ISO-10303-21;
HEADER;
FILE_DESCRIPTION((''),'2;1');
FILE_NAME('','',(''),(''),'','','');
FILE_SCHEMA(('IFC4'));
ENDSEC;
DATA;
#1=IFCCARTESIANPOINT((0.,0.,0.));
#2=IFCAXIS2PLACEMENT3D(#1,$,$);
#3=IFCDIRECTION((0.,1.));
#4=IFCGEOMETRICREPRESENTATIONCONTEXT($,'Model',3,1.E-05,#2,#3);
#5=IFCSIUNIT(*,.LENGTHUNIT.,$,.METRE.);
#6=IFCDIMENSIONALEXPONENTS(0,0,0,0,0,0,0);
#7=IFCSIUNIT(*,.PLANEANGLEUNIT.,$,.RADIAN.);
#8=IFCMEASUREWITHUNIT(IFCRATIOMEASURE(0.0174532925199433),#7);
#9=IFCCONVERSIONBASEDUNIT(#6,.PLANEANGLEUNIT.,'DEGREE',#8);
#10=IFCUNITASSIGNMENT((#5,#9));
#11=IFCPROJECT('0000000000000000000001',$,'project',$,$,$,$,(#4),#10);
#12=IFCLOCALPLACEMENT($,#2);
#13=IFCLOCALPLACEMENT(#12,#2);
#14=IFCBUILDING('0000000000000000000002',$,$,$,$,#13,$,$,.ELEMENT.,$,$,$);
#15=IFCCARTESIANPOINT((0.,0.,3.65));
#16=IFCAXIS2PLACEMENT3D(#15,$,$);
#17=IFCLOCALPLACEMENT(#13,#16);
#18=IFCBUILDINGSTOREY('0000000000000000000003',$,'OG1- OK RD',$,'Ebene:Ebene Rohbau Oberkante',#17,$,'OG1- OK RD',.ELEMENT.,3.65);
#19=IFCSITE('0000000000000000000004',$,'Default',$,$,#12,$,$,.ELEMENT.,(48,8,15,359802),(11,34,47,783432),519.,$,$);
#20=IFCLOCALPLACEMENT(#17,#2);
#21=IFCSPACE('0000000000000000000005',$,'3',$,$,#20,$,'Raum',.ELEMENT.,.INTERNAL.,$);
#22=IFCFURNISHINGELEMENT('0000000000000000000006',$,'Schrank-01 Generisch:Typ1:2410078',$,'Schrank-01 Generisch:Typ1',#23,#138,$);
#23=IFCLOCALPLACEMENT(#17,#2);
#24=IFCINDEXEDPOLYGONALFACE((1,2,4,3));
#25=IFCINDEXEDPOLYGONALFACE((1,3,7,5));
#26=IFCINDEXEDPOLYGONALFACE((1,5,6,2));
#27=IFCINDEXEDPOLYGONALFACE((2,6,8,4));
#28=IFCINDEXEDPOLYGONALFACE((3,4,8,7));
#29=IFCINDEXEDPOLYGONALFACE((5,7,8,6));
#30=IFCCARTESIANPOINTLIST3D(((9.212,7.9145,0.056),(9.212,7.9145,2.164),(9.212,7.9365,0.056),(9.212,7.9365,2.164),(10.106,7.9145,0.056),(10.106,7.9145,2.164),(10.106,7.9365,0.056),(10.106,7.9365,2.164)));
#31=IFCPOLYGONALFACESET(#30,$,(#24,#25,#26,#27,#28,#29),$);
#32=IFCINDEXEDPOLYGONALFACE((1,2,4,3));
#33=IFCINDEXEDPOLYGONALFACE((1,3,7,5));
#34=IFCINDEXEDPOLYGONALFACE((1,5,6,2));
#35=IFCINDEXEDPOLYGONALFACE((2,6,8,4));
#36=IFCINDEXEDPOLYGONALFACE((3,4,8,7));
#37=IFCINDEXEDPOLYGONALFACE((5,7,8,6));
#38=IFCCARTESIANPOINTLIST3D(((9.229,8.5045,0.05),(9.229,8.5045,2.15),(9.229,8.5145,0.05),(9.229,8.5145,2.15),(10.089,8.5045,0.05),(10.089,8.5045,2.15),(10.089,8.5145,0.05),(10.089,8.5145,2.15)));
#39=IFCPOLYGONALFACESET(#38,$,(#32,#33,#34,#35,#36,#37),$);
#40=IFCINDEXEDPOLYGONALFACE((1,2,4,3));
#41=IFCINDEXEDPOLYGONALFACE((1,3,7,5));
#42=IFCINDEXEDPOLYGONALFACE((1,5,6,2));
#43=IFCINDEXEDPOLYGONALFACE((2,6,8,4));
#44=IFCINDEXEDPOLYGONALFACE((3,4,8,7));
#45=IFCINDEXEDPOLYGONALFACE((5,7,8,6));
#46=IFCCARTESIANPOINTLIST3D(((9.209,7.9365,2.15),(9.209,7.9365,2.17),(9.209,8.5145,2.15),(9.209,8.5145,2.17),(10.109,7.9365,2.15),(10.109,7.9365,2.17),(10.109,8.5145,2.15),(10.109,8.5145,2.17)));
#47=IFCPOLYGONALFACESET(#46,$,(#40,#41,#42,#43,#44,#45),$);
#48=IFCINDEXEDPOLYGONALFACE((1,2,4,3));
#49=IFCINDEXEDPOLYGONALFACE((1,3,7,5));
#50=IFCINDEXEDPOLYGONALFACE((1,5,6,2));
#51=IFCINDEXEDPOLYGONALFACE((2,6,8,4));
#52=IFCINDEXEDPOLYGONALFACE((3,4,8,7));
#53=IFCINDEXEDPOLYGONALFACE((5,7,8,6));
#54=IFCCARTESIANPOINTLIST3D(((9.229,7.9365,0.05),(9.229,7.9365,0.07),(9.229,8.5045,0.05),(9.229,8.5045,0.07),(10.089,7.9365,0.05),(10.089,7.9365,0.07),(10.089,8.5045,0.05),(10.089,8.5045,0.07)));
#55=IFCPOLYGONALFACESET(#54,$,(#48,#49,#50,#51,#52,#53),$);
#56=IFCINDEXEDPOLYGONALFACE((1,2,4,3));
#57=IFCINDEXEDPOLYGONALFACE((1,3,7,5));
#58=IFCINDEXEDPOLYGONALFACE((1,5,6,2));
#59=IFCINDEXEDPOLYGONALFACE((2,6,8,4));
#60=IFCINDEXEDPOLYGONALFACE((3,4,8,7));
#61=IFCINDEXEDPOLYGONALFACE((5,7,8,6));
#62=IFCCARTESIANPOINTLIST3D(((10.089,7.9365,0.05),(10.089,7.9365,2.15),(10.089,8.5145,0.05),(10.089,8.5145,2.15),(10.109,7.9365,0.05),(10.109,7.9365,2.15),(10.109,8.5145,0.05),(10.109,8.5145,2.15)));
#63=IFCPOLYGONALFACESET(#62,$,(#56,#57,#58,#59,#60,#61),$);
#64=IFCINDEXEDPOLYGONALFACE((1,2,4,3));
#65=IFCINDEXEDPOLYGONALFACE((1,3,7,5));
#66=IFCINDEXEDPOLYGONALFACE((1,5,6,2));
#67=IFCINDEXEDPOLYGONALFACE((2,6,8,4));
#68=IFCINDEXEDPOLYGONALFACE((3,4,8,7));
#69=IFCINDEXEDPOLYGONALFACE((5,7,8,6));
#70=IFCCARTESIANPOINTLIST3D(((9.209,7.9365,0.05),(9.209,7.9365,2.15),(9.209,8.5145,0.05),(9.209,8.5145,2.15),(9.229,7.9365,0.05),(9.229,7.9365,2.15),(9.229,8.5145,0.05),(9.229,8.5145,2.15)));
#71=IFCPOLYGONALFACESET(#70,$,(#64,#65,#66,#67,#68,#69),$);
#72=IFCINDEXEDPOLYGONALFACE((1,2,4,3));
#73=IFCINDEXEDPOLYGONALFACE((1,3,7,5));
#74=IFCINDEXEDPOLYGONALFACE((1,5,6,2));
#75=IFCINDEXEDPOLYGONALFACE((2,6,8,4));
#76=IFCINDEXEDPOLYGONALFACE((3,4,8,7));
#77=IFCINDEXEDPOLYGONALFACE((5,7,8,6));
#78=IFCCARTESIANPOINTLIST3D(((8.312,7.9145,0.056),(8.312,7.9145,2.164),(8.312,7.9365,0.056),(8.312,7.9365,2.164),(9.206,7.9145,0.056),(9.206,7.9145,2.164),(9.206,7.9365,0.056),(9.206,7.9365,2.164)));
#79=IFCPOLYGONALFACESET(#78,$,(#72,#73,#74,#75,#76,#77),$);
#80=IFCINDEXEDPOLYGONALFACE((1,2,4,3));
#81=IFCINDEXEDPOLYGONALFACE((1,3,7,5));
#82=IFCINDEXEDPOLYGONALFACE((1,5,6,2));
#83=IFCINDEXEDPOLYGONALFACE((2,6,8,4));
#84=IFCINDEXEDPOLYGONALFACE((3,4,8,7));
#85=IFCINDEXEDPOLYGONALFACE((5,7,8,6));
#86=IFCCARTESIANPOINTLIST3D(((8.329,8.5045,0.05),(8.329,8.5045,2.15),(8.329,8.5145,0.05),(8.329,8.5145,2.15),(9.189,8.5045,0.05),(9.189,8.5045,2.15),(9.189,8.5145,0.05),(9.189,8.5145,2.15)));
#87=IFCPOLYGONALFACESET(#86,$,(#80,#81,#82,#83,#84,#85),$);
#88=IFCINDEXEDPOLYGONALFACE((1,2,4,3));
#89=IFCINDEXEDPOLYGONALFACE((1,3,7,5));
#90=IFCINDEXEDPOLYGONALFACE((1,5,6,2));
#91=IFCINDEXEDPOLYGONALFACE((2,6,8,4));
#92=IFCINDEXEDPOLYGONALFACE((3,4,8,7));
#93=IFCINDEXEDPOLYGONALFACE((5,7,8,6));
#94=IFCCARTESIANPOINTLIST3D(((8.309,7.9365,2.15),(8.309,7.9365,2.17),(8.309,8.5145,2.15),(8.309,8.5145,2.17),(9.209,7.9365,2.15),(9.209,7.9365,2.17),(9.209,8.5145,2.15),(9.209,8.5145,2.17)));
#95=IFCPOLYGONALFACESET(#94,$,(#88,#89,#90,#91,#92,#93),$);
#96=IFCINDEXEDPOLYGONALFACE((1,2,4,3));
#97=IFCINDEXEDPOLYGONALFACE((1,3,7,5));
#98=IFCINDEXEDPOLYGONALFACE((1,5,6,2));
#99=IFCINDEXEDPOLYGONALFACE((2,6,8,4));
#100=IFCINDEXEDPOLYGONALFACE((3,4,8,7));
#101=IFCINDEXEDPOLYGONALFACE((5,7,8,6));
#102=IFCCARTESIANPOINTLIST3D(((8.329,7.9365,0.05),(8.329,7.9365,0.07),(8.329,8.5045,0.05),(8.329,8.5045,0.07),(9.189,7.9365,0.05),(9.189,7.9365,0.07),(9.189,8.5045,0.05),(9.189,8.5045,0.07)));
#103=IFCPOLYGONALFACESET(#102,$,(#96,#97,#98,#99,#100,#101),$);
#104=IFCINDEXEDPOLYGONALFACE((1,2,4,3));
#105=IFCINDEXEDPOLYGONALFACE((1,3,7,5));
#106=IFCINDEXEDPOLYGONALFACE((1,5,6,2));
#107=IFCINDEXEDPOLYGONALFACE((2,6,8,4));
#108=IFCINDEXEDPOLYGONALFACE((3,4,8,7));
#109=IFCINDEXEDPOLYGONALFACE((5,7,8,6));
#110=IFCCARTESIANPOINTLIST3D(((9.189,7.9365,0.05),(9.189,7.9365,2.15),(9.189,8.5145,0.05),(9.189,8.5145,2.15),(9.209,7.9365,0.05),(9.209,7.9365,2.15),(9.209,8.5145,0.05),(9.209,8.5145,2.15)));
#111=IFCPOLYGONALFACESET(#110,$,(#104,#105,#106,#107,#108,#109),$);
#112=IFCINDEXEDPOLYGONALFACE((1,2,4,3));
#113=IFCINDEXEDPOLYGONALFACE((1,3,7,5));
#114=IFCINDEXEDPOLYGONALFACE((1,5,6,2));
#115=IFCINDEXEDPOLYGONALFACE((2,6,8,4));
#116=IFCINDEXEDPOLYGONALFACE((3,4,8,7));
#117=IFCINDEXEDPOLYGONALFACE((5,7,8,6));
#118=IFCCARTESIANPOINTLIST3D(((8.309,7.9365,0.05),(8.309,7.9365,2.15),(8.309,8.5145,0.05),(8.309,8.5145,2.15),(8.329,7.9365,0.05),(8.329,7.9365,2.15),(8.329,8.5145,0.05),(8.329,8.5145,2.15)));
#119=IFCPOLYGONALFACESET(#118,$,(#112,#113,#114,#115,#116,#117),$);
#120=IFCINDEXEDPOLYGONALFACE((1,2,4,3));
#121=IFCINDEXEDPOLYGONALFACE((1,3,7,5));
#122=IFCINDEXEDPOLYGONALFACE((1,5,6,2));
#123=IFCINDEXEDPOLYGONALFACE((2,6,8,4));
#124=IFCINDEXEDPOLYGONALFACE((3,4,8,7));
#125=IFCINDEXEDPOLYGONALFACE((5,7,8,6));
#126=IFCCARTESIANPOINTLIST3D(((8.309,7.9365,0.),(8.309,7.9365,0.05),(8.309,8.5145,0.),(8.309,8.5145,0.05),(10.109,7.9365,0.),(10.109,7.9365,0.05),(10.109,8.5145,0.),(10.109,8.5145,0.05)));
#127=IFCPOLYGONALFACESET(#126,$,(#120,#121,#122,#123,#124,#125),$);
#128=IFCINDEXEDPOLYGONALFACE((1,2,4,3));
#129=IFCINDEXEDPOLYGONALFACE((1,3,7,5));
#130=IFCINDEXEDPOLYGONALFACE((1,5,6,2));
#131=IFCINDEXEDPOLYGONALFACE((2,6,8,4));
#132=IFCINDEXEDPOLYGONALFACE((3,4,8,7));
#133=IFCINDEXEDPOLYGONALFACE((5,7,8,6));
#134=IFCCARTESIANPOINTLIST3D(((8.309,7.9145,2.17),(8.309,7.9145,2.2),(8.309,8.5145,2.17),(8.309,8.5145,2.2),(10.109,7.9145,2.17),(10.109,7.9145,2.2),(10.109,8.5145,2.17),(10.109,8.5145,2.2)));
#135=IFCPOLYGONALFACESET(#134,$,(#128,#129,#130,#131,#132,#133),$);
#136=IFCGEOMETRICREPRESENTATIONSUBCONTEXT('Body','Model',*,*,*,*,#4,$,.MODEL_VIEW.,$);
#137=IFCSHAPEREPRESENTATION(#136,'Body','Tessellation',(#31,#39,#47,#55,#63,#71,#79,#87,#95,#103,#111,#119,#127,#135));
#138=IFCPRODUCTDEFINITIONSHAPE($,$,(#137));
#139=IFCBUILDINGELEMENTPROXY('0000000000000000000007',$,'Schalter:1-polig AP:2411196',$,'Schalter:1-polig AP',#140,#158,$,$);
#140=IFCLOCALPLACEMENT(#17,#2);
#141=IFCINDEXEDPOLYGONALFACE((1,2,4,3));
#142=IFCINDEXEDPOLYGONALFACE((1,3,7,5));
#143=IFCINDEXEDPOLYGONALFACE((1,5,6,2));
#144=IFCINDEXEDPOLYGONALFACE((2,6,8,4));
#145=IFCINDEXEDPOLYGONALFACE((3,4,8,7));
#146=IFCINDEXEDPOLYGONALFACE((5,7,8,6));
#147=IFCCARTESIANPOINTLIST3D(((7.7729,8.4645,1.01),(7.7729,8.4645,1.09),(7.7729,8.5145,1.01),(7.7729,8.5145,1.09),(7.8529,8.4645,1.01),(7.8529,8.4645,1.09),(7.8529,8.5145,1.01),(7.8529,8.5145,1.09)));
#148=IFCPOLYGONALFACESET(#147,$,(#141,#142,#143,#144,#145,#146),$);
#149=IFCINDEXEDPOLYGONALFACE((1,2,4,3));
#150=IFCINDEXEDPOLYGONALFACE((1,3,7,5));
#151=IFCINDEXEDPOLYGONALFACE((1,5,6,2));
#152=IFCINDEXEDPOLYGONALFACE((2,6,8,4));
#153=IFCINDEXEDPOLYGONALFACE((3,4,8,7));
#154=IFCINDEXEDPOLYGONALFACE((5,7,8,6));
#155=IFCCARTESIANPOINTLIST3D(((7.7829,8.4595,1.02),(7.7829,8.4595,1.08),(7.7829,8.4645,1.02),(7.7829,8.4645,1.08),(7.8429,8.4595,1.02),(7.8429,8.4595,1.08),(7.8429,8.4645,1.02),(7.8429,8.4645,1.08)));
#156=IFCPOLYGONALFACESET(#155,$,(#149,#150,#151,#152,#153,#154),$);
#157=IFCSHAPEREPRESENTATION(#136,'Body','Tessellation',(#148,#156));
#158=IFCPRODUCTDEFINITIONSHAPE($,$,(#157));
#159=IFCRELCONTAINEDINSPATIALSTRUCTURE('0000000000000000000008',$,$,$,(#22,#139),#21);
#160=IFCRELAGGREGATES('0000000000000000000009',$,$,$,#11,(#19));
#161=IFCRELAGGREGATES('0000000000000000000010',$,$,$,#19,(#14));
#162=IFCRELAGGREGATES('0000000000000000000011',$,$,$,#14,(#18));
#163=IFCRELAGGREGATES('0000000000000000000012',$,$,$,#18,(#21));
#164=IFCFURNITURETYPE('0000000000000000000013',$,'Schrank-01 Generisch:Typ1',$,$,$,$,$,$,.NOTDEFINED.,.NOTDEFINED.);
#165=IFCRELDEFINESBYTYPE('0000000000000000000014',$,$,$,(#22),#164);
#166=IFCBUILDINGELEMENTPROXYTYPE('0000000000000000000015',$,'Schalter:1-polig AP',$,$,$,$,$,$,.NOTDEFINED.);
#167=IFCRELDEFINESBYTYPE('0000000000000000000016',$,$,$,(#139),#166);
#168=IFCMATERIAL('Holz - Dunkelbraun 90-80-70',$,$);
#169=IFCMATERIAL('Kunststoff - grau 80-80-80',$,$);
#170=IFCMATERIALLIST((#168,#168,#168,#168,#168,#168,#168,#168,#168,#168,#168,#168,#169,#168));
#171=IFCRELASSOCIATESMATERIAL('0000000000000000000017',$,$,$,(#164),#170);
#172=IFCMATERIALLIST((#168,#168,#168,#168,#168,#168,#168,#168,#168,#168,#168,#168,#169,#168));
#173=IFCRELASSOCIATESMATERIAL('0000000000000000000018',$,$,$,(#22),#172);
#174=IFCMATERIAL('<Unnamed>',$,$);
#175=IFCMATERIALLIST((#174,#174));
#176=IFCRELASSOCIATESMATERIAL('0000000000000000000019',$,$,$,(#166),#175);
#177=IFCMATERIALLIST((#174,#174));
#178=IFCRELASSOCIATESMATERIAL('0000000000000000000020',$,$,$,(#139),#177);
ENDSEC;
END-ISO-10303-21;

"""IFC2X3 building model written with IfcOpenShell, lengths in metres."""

from ifc_helpers import new_model, entity, si_unit, converted_unit, direction, frame, frame_2d, origin, origin_2d_with_axis, place, context, subcontext, project, spatial, rectangle, extrude, source, transform, mapped, material, material_list, type_object, type_shapes, element, save


model = new_model("IFC2X3")

# Units and contexts
model_context = context("Model", 3, precision=1e-05, world=origin(), true_north=direction((0.0, 1.0)))
body_context = subcontext(model_context, "Body", "Model", "MODEL_VIEW")
ifc_project = project(units=[si_unit("LENGTHUNIT", "METRE"), converted_unit("PLANEANGLEUNIT", "DEGREE", entity("IfcRatioMeasure", 0.0174532925199433), si_unit("PLANEANGLEUNIT", "RADIAN"), dimensions=[0, 0, 0, 0, 0, 0, 0])], contexts=[model_context])

# Site, building, storey
site_placement = place(None, origin())
site = spatial("IfcSite", under=ifc_project, at=site_placement, Name="Default", CompositionType="ELEMENT", RefLatitude=(48, 8, 15, 359802), RefLongitude=(11, 34, 47, 783432), RefElevation=519.0)
building_placement = place(site_placement, origin())
building = spatial("IfcBuilding", under=site, at=building_placement, CompositionType="ELEMENT")
storey_placement = place(building_placement, frame((0.0, 0.0, 3.65)))
storey = spatial("IfcBuildingStorey", under=building, at=storey_placement, Name="OG1- OK RD", ObjectType="Ebene:Ebene Rohbau Oberkante", LongName="OG1- OK RD", CompositionType="ELEMENT", Elevation=3.65)

# Shared definitions
space_placement = place(storey_placement, origin())
space = spatial("IfcSpace", under=storey, at=space_placement, Name="3", LongName="Raum", CompositionType="ELEMENT", InteriorOrExteriorSpace="INTERNAL")

# Furnishing element
ifc_material_1 = material(Name="Holz - Dunkelbraun 90-80-70")
ifc_material_2 = material(Name="Kunststoff - grau 80-80-80")
ifc_material_list_1 = material_list([ifc_material_1, ifc_material_1, ifc_material_1, ifc_material_1, ifc_material_1, ifc_material_1, ifc_material_1, ifc_material_1, ifc_material_1, ifc_material_1, ifc_material_1, ifc_material_1, ifc_material_2, ifc_material_1])
ifc_material_list_2 = material_list([ifc_material_1, ifc_material_1, ifc_material_1, ifc_material_1, ifc_material_1, ifc_material_1, ifc_material_1, ifc_material_1, ifc_material_1, ifc_material_1, ifc_material_1, ifc_material_1, ifc_material_2, ifc_material_1])
furniture_type_1 = type_object("IfcFurnitureType", Name="Schrank-01 Generisch:Typ1", material=ifc_material_list_2)
shared_shape_1 = source(origin(), body_context, "Body", "SweptSolid", [
    extrude(rectangle(XDim=0.894, YDim=0.022, at=frame_2d((0.0, 0.0), x_axis=(1.0, 0.0))), frame((0.45, -0.289, 0.056), z_axis=(0.0, 0.0, 1.0), x_axis=(-1.0, 0.0, 0.0)), (0.0, 0.0, 1.0), 2.108),
    extrude(rectangle(XDim=0.86, YDim=0.01, at=origin_2d_with_axis()), frame((0.45, 0.295, 0.05), z_axis=(0.0, 0.0, 1.0), x_axis=(-1.0, 0.0, 0.0)), (0.0, 0.0, 1.0), 2.1),
    extrude(rectangle(XDim=0.9, YDim=0.578, at=origin_2d_with_axis()), frame((0.45, 0.011, 2.15), z_axis=(0.0, 0.0, 1.0), x_axis=(-1.0, 0.0, 0.0)), (0.0, 0.0, 1.0), 0.02),
    extrude(rectangle(XDim=0.86, YDim=0.568, at=origin_2d_with_axis()), frame((0.45, 0.006, 0.05), z_axis=(0.0, 0.0, 1.0), x_axis=(-1.0, 0.0, 0.0)), (0.0, 0.0, 1.0), 0.02),
    extrude(rectangle(XDim=0.02, YDim=0.578, at=origin_2d_with_axis()), frame((0.89, 0.011, 0.05), z_axis=(0.0, 0.0, 1.0), x_axis=(-1.0, 0.0, 0.0)), (0.0, 0.0, 1.0), 2.1),
    extrude(rectangle(XDim=0.02, YDim=0.578, at=origin_2d_with_axis()), frame((0.01, 0.011, 0.05), z_axis=(0.0, 0.0, 1.0), x_axis=(-1.0, 0.0, 0.0)), (0.0, 0.0, 1.0), 2.1),
    extrude(rectangle(XDim=0.894, YDim=0.022, at=frame_2d((0.0, 0.0), x_axis=(1.0, 0.0))), frame((-0.45, -0.289, 0.056), z_axis=(0.0, 0.0, 1.0), x_axis=(-1.0, 0.0, 0.0)), (0.0, 0.0, 1.0), 2.108),
    extrude(rectangle(XDim=0.86, YDim=0.01, at=frame_2d((0.0, 0.0), x_axis=(1.0, 0.0))), frame((-0.45, 0.295, 0.05), z_axis=(0.0, 0.0, 1.0), x_axis=(-1.0, 0.0, 0.0)), (0.0, 0.0, 1.0), 2.1),
    extrude(rectangle(XDim=0.9, YDim=0.578, at=frame_2d((0.0, 0.0), x_axis=(1.0, 0.0))), frame((-0.45, 0.011, 2.15), z_axis=(0.0, 0.0, 1.0), x_axis=(-1.0, 0.0, 0.0)), (0.0, 0.0, 1.0), 0.02),
    extrude(rectangle(XDim=0.86, YDim=0.568, at=frame_2d((0.0, 0.0), x_axis=(1.0, 0.0))), frame((-0.45, 0.006, 0.05), z_axis=(0.0, 0.0, 1.0), x_axis=(-1.0, 0.0, 0.0)), (0.0, 0.0, 1.0), 0.02),
    extrude(rectangle(XDim=0.02, YDim=0.578, at=origin_2d_with_axis()), frame((-0.01, 0.011, 0.05), z_axis=(0.0, 0.0, 1.0), x_axis=(-1.0, 0.0, 0.0)), (0.0, 0.0, 1.0), 2.1),
    extrude(rectangle(XDim=0.02, YDim=0.578, at=origin_2d_with_axis()), frame((-0.89, 0.011, 0.05), z_axis=(0.0, 0.0, 1.0), x_axis=(-1.0, 0.0, 0.0)), (0.0, 0.0, 1.0), 2.1),
    extrude(rectangle(XDim=1.8, YDim=0.578, at=origin_2d_with_axis()), frame((0.0, 0.011, 0.0), z_axis=(0.0, 0.0, 1.0), x_axis=(-1.0, 0.0, 0.0)), (0.0, 0.0, 1.0), 0.05),
    extrude(rectangle(XDim=1.8, YDim=0.6, at=origin_2d_with_axis()), frame((0.0, 0.0, 2.17), z_axis=(0.0, 0.0, 1.0), x_axis=(-1.0, 0.0, 0.0)), (0.0, 0.0, 1.0), 0.03),
])
type_shapes(furniture_type_1, [shared_shape_1])
furnishing_1_placement = place(space_placement, frame((9.209, 8.2145, 0.0)))
element("IfcFurnishingElement", 1, at=furnishing_1_placement, inside=space, type_object=furniture_type_1, material=ifc_material_list_1, Name="Schrank-01 Generisch:Typ1:2410078", ObjectType="Schrank-01 Generisch:Typ1", context=body_context, shape_type="MappedRepresentation", body=[
    mapped(shared_shape_1, transform((0.0, 0.0, 0.0), scale=1.0)),
])

# Building element proxy
ifc_material_3 = material(Name="<Unnamed>")
ifc_material_list_3 = material_list([ifc_material_3, ifc_material_3])
ifc_material_list_4 = material_list([ifc_material_3, ifc_material_3])
building_element_proxy_type = type_object("IfcBuildingElementProxyType", Name="Schalter:1-polig AP", PredefinedType="NOTDEFINED", material=ifc_material_list_4)
shared_shape_2 = source(origin(), body_context, "Body", "SweptSolid", [
    extrude(rectangle(XDim=0.05, YDim=0.08, at=origin_2d_with_axis()), frame((0.0, -0.025, 1.01), z_axis=(0.0, 0.0, 1.0), x_axis=(0.0, 1.0, 0.0)), (0.0, 0.0, 1.0), 0.08),
    extrude(rectangle(XDim=0.005, YDim=0.06, at=frame_2d((0.0, 0.0), x_axis=(1.0, 0.0))), frame((0.0, -0.0525, 1.02), z_axis=(0.0, 0.0, 1.0), x_axis=(0.0, 1.0, 0.0)), (0.0, 0.0, 1.0), 0.06),
])
type_shapes(building_element_proxy_type, [shared_shape_2])
proxy_placement = place(space_placement, frame((7.8129, 8.5145, 0.0)))
element("IfcBuildingElementProxy", 2, at=proxy_placement, inside=space, type_object=building_element_proxy_type, material=ifc_material_list_3, Name="Schalter:1-polig AP:2411196", ObjectType="Schalter:1-polig AP", context=body_context, shape_type="MappedRepresentation", body=[
    mapped(shared_shape_2, transform((0.0, 0.0, 0.0), scale=1.0)),
])

save(model, "model.ifc")
